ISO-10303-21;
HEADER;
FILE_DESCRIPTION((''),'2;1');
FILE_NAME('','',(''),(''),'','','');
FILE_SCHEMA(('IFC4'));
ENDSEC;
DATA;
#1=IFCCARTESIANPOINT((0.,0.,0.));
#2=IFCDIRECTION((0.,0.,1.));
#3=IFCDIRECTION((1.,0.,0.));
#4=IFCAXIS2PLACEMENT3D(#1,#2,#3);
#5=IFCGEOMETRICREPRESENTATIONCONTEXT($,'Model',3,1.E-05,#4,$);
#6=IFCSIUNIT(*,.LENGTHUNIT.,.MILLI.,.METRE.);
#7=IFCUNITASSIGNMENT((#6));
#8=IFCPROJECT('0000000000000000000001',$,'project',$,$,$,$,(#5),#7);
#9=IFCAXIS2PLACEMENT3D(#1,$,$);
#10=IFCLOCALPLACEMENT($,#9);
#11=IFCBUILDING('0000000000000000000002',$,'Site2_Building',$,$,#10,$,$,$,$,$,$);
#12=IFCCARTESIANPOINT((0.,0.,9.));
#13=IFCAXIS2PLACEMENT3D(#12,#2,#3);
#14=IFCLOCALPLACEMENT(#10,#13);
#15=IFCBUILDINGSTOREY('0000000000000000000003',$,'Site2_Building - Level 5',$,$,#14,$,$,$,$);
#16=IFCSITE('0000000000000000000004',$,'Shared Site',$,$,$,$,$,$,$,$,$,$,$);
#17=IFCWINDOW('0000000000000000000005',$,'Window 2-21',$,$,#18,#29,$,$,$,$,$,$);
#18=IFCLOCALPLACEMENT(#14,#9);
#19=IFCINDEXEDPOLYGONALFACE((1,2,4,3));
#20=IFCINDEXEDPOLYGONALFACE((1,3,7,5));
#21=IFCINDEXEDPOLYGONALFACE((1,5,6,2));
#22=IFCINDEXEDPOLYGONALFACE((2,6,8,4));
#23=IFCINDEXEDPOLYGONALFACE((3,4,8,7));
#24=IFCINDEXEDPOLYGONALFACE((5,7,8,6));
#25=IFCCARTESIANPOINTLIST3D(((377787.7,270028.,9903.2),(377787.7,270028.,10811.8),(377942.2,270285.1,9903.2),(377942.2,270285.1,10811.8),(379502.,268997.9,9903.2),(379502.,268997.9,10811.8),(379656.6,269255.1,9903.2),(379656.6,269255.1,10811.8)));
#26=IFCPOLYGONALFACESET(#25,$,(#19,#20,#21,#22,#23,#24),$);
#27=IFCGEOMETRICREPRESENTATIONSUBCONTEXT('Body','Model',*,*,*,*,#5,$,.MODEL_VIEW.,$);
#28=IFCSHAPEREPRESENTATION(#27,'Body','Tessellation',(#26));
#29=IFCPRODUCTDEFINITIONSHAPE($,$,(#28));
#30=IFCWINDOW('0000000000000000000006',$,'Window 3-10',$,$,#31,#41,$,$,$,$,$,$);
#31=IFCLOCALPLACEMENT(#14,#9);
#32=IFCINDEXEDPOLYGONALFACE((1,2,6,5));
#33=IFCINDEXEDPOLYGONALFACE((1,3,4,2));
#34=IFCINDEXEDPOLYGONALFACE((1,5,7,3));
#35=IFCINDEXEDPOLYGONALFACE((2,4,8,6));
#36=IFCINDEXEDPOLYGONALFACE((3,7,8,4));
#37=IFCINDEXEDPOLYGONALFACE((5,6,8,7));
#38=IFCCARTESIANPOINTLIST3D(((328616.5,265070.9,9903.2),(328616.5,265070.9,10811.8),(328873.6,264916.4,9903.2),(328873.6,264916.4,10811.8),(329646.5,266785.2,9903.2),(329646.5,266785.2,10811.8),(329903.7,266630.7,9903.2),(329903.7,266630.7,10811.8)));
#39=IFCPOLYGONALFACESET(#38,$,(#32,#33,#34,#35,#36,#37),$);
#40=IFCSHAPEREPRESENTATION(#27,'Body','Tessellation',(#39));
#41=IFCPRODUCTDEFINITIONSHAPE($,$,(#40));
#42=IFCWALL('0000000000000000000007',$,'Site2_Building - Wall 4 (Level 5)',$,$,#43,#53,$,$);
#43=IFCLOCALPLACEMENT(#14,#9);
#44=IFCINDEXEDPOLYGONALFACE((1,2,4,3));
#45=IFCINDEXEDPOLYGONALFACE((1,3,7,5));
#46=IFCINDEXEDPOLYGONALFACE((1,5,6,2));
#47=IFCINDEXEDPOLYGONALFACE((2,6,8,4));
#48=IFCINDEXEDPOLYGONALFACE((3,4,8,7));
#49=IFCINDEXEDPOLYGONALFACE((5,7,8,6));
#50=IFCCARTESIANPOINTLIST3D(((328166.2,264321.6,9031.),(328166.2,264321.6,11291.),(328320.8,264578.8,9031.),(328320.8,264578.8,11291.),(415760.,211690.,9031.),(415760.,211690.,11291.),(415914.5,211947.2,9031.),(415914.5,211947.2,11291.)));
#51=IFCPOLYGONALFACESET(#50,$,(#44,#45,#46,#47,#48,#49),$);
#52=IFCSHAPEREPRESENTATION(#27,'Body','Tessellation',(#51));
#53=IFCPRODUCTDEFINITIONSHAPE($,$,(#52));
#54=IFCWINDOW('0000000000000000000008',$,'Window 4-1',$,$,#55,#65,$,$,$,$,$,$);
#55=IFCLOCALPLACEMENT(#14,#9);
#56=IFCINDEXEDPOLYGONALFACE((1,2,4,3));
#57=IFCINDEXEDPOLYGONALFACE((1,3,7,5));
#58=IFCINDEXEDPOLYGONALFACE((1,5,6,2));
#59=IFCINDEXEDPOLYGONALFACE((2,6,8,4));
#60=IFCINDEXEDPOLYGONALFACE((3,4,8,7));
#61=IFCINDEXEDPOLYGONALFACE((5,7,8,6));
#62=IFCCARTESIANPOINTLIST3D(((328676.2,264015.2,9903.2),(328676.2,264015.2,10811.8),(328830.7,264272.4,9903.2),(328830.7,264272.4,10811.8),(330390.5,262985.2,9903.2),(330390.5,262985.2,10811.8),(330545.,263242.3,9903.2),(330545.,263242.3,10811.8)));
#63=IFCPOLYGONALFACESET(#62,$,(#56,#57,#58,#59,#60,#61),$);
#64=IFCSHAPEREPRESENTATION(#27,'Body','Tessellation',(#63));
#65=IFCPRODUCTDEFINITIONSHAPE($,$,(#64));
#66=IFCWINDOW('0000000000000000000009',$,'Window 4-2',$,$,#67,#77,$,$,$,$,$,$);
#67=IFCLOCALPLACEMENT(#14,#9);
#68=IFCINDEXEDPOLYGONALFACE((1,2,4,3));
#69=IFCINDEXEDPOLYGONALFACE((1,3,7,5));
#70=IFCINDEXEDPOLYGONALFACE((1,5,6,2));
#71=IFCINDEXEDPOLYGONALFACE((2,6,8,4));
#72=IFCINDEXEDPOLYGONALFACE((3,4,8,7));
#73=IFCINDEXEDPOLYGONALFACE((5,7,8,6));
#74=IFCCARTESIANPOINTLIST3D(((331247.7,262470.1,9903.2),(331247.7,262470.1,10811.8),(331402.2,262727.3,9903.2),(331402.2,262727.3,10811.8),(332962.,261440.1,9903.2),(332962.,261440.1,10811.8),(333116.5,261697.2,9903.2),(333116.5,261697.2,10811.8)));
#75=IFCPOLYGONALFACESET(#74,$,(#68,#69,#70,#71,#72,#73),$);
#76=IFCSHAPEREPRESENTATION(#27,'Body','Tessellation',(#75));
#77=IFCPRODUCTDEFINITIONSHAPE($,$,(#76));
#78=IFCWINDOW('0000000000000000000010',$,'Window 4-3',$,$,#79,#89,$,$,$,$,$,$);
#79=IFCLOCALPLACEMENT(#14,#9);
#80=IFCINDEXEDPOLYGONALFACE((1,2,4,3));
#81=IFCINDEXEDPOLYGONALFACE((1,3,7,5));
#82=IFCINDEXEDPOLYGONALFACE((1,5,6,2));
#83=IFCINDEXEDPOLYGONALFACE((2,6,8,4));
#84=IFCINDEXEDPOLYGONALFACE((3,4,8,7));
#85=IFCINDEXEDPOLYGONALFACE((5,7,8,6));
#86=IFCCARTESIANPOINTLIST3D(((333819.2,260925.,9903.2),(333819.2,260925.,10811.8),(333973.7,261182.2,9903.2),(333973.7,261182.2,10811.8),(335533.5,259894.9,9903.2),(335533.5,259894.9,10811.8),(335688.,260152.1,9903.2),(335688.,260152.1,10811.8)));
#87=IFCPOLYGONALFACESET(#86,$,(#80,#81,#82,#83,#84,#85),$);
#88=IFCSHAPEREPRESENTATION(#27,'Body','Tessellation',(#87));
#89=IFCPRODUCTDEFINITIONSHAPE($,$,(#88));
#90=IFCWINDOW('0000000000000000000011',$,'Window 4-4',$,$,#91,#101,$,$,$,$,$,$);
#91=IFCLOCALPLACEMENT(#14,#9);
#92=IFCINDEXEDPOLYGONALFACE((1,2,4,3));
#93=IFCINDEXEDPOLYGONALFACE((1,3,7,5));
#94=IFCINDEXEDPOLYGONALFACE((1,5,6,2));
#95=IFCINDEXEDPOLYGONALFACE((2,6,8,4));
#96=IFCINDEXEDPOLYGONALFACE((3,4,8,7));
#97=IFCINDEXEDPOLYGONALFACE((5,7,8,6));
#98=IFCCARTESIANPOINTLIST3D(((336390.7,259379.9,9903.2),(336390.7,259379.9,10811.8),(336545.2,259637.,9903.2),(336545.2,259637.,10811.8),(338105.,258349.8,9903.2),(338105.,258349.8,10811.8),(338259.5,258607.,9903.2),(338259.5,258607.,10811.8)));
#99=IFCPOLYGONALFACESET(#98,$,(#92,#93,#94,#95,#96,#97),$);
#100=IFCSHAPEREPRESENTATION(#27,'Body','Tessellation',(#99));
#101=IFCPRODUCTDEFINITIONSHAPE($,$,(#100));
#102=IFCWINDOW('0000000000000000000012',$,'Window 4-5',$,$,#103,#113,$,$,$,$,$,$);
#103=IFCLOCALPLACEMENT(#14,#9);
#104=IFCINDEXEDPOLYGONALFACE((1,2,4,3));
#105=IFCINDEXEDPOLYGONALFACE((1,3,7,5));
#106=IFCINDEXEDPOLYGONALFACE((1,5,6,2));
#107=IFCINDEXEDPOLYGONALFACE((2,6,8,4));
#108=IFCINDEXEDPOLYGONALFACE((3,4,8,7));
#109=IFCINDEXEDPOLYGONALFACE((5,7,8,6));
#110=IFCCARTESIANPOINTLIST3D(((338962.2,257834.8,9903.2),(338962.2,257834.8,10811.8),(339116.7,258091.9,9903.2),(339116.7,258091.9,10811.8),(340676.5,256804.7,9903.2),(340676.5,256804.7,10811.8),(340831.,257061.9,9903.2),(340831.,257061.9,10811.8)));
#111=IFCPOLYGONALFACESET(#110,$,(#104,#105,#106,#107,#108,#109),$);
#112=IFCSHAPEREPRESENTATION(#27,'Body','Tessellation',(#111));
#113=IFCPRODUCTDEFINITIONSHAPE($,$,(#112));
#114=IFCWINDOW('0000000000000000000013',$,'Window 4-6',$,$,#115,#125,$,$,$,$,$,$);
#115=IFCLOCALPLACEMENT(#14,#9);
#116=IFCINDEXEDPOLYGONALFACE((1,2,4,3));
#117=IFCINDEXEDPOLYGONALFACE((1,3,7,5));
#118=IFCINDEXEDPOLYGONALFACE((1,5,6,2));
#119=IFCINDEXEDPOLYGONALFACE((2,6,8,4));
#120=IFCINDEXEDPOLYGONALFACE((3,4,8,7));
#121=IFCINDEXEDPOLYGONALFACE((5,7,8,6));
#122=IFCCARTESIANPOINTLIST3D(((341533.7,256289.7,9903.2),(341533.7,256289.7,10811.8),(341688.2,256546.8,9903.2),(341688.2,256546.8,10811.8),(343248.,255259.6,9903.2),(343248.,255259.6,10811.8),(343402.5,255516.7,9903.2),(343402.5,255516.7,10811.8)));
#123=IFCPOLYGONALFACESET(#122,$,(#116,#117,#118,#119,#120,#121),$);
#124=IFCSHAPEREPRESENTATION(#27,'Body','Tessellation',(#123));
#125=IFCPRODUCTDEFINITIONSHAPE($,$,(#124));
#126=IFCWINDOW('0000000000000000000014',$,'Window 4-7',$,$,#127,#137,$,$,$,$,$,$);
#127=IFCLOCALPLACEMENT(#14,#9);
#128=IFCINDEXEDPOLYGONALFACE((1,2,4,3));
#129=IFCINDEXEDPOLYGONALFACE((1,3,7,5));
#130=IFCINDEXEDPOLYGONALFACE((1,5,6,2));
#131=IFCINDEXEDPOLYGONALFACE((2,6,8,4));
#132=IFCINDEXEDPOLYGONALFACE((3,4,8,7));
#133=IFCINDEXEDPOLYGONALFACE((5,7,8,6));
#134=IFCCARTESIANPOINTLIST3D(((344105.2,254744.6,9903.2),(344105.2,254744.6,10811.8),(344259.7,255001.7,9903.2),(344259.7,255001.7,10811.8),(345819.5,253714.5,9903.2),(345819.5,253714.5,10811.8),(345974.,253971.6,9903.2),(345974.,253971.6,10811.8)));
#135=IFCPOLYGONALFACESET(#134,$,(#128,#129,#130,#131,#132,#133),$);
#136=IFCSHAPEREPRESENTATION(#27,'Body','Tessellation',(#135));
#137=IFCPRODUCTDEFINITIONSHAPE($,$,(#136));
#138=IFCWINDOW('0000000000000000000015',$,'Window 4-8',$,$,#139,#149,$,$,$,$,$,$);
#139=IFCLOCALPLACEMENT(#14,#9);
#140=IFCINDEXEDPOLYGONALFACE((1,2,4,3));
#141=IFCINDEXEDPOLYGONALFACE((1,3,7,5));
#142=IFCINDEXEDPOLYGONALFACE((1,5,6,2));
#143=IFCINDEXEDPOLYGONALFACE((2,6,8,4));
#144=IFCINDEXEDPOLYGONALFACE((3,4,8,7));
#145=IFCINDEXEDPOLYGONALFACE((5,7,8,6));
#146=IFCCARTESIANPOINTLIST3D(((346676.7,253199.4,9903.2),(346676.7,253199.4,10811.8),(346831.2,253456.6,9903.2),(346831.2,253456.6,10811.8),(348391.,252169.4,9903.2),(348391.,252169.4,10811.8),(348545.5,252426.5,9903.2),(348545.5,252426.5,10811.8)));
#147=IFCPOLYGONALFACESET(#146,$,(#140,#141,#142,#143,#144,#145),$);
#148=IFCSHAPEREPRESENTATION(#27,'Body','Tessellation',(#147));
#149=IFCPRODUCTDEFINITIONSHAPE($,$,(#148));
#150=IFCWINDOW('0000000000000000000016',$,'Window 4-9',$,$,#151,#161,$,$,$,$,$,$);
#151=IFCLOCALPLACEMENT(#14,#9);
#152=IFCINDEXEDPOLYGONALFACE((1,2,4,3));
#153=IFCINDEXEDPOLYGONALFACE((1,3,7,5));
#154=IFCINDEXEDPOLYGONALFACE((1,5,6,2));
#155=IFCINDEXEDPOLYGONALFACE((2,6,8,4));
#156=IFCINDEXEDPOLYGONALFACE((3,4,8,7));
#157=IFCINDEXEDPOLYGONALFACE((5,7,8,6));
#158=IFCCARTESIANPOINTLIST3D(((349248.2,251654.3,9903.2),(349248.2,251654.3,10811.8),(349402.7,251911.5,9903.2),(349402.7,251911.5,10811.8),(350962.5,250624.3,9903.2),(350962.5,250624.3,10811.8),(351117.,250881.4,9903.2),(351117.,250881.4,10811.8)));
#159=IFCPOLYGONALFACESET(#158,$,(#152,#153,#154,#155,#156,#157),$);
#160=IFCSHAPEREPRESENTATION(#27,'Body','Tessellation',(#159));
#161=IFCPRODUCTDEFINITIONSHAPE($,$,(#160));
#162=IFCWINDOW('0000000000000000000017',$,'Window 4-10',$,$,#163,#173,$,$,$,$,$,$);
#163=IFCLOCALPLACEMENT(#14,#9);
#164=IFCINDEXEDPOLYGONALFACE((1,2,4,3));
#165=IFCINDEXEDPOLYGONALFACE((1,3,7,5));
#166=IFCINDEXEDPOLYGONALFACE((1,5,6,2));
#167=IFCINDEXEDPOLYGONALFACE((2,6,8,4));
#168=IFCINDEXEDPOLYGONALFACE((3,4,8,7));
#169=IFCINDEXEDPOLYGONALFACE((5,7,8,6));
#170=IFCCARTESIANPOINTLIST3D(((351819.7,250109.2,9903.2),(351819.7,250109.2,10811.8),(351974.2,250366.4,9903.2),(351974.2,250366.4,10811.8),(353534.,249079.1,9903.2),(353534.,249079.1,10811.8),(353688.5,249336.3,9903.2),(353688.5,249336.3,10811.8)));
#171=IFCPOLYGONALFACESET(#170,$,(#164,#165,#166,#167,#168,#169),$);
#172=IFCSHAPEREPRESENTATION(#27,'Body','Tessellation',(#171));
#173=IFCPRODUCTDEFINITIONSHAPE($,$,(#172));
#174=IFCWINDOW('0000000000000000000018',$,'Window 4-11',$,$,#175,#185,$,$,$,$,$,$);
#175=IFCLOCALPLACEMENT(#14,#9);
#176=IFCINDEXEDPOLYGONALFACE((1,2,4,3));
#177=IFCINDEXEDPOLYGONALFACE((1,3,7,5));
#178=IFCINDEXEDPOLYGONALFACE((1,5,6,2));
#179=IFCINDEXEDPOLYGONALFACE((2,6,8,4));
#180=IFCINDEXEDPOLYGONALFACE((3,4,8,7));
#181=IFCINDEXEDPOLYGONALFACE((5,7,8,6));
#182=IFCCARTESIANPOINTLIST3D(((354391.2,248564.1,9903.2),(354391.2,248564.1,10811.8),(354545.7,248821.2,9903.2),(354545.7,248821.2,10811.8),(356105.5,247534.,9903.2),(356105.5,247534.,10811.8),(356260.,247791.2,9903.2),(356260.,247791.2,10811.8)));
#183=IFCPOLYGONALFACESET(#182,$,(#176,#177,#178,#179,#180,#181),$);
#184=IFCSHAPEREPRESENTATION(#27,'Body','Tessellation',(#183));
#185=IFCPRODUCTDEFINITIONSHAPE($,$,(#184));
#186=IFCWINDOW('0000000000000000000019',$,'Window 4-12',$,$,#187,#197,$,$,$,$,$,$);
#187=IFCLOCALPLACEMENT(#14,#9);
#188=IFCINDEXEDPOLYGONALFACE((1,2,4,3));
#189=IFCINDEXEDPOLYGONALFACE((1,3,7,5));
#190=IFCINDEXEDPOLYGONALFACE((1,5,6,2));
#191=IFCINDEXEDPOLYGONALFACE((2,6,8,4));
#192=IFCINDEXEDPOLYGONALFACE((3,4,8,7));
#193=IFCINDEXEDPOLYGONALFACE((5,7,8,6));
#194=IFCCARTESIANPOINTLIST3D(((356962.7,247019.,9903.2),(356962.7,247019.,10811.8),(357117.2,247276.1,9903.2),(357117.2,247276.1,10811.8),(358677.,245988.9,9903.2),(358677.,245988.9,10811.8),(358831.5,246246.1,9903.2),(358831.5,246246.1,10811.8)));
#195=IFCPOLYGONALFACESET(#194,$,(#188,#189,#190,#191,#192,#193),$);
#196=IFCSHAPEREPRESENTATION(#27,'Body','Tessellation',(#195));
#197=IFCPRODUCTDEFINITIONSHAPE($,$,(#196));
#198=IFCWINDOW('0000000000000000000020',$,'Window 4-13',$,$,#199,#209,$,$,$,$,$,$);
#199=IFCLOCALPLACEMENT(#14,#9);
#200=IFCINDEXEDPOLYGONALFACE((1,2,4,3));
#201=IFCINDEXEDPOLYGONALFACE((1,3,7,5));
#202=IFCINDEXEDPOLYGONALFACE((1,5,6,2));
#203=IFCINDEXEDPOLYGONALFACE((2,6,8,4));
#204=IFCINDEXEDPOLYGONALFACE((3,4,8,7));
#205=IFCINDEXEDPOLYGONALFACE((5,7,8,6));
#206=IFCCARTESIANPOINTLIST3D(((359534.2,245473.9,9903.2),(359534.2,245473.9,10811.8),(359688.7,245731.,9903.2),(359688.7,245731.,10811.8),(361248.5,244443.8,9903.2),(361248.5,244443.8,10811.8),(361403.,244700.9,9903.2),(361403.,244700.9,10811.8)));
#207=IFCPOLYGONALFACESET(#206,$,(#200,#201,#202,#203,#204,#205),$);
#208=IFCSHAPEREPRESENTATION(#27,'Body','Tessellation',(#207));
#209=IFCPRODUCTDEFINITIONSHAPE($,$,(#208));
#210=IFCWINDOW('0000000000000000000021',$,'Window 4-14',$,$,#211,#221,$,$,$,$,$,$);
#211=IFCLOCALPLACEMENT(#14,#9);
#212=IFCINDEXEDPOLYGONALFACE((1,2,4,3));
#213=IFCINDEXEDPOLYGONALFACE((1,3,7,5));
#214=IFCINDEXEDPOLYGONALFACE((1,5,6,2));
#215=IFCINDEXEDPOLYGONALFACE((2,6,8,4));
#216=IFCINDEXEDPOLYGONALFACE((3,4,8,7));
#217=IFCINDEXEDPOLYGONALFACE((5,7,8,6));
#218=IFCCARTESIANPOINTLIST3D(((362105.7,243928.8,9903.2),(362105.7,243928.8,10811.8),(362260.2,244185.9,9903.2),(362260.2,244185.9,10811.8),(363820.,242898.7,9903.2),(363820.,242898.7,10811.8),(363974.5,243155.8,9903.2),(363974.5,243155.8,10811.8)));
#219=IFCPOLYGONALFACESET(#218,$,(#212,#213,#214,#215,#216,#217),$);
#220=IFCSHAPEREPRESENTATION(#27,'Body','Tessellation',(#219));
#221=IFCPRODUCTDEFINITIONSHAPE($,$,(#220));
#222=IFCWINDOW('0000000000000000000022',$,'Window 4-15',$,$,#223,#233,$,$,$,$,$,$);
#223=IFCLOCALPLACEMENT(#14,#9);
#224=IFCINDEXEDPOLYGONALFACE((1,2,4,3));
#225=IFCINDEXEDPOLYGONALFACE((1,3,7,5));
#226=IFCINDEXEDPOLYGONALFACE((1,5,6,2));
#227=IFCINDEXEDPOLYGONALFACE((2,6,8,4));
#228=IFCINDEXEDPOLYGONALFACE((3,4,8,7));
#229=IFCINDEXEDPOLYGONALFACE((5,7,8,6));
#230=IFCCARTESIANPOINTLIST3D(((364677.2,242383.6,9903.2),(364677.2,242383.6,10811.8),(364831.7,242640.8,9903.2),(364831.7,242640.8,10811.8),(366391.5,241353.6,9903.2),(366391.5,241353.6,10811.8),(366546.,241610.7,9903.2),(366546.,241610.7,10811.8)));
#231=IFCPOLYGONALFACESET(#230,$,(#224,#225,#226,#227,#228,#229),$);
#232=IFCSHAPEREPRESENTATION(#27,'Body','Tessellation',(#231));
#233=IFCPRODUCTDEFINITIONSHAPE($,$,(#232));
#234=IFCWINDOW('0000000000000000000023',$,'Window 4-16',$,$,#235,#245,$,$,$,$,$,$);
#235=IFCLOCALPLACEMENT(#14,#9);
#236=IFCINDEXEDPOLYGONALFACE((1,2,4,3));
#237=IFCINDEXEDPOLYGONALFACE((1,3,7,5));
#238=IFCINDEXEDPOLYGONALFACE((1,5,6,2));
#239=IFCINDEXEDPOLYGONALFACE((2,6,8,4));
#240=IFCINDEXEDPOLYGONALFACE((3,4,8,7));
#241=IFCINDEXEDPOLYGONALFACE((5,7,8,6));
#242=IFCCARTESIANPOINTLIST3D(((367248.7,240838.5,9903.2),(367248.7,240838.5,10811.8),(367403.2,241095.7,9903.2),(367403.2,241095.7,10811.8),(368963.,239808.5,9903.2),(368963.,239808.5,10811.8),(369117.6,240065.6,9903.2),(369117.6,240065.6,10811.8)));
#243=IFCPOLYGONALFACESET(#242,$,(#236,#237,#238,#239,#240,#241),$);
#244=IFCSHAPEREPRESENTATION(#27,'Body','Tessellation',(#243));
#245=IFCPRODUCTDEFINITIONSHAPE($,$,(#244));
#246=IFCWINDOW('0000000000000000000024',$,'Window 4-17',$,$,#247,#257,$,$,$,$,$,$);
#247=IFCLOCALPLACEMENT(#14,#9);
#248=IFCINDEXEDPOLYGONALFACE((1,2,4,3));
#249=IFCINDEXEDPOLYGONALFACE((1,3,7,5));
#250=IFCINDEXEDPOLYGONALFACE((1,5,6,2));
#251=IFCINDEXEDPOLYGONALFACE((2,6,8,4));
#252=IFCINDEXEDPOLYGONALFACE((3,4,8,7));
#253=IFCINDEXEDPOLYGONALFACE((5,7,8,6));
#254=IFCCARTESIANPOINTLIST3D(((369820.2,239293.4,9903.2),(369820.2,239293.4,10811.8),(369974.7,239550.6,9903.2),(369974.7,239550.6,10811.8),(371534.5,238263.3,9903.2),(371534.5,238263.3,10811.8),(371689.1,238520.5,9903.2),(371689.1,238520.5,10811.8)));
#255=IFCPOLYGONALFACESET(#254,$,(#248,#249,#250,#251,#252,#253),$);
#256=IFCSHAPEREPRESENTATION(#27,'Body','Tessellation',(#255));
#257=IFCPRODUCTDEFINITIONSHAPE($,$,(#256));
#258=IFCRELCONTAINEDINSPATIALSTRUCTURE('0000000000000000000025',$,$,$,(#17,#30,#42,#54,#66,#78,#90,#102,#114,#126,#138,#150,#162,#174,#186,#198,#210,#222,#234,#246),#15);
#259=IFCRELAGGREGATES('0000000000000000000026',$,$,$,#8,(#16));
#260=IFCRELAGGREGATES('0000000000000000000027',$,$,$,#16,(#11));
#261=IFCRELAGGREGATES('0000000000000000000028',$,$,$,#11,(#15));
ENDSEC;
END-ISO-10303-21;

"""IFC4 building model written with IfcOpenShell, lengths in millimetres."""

from ifc_helpers import new_model, si_unit, frame, origin, origin_with_axes, place, context, subcontext, project, spatial, indexed_curve, outline, extrude, element, save


model = new_model("IFC4")

# Units and contexts
model_context = context("Model", 3, precision=1e-05, world=origin_with_axes())
body_context = subcontext(model_context, "Body", "Model", "MODEL_VIEW")
ifc_project = project(units=[si_unit("LENGTHUNIT", "METRE", prefix="MILLI")], contexts=[model_context])

# Site, building, storey
site = spatial("IfcSite", under=ifc_project, Name="Shared Site")
building_placement = place(None, origin())
building = spatial("IfcBuilding", under=site, at=building_placement, Name="Site2_Building")
storey_placement = place(building_placement, frame((0.0, 0.0, 9.0), z_axis=(0.0, 0.0, 1.0), x_axis=(1.0, 0.0, 0.0)))
storey = spatial("IfcBuildingStorey", under=building, at=storey_placement, Name="Site2_Building - Level 5")

# Windows
for number, where, z_axis, x_axis, name in (
    (1, (379656.6, 269255.1, 9903.2), (0.0, 0.0, 1.0), (-0.857167, 0.515038, 0.0), "Window 2-21"),
    (2, (329646.5, 266785.2, 9903.2), (0.0, 0.0, 1.0), (-0.515038, -0.857167, 0.0), "Window 3-10"),
):
    element("IfcWindow", number, at=place(storey_placement, frame(where, z_axis=z_axis, x_axis=x_axis)), inside=storey, Name=name, context=body_context, shape_type="SweptSolid", body=[
        extrude(outline(indexed_curve([(0.0, 0.0), (0.0, 300.0), (2000.0, 300.0), (2000.0, 0.0), (0.0, 0.0)], self_intersect=False)), origin_with_axes(), (0.0, 0.0, 1.0), 908.6),
    ])

# Wall
wall_placement = place(storey_placement, frame((328166.2, 264321.6, 9031.0), z_axis=(0.0, 0.0, 1.0), x_axis=(0.857167, -0.515038, 0.0)))
element("IfcWall", 3, at=wall_placement, inside=storey, Name="Site2_Building - Wall 4 (Level 5)", context=body_context, shape_type="SweptSolid", body=[
    extrude(outline(indexed_curve([(0.0, 0.0), (0.0, 300.0), (102189.8, 300.0), (102189.8, 0.0), (0.0, 0.0)], self_intersect=False)), origin_with_axes(), (0.0, 0.0, 1.0), 2260.0),
])

# Windows
for number, where, z_axis, x_axis, name in (
    (4, (328676.2, 264015.2, 9903.2), (0.0, 0.0, 1.0), (0.857167, -0.515038, 0.0), "Window 4-1"),
    (5, (331247.7, 262470.1, 9903.2), (0.0, 0.0, 1.0), (0.857167, -0.515038, 0.0), "Window 4-2"),
    (6, (333819.2, 260925.0, 9903.2), (0.0, 0.0, 1.0), (0.857167, -0.515038, 0.0), "Window 4-3"),
    (7, (336390.7, 259379.9, 9903.2), (0.0, 0.0, 1.0), (0.857167, -0.515038, 0.0), "Window 4-4"),
    (8, (338962.2, 257834.8, 9903.2), (0.0, 0.0, 1.0), (0.857167, -0.515038, 0.0), "Window 4-5"),
    (9, (341533.7, 256289.7, 9903.2), (0.0, 0.0, 1.0), (0.857167, -0.515038, 0.0), "Window 4-6"),
    (10, (344105.2, 254744.6, 9903.2), (0.0, 0.0, 1.0), (0.857167, -0.515038, 0.0), "Window 4-7"),
    (11, (346676.7, 253199.4, 9903.2), (0.0, 0.0, 1.0), (0.857167, -0.515038, 0.0), "Window 4-8"),
    (12, (349248.2, 251654.3, 9903.2), (0.0, 0.0, 1.0), (0.857167, -0.515038, 0.0), "Window 4-9"),
    (13, (351819.7, 250109.2, 9903.2), (0.0, 0.0, 1.0), (0.857167, -0.515038, 0.0), "Window 4-10"),
    (14, (354391.2, 248564.1, 9903.2), (0.0, 0.0, 1.0), (0.857167, -0.515038, 0.0), "Window 4-11"),
    (15, (356962.7, 247019.0, 9903.2), (0.0, 0.0, 1.0), (0.857167, -0.515038, 0.0), "Window 4-12"),
    (16, (359534.2, 245473.9, 9903.2), (0.0, 0.0, 1.0), (0.857167, -0.515038, 0.0), "Window 4-13"),
    (17, (362105.7, 243928.8, 9903.2), (0.0, 0.0, 1.0), (0.857167, -0.515038, 0.0), "Window 4-14"),
    (18, (364677.2, 242383.6, 9903.2), (0.0, 0.0, 1.0), (0.857167, -0.515038, 0.0), "Window 4-15"),
    (19, (367248.7, 240838.5, 9903.2), (0.0, 0.0, 1.0), (0.857167, -0.515038, 0.0), "Window 4-16"),
    (20, (369820.2, 239293.4, 9903.2), (0.0, 0.0, 1.0), (0.857167, -0.515038, 0.0), "Window 4-17"),
):
    element("IfcWindow", number, at=place(storey_placement, frame(where, z_axis=z_axis, x_axis=x_axis)), inside=storey, Name=name, context=body_context, shape_type="SweptSolid", body=[
        extrude(outline(indexed_curve([(0.0, 0.0), (0.0, 300.0), (2000.0, 300.0), (2000.0, 0.0), (0.0, 0.0)], self_intersect=False)), origin_with_axes(), (0.0, 0.0, 1.0), 908.6),
    ])

save(model, "model.ifc")
